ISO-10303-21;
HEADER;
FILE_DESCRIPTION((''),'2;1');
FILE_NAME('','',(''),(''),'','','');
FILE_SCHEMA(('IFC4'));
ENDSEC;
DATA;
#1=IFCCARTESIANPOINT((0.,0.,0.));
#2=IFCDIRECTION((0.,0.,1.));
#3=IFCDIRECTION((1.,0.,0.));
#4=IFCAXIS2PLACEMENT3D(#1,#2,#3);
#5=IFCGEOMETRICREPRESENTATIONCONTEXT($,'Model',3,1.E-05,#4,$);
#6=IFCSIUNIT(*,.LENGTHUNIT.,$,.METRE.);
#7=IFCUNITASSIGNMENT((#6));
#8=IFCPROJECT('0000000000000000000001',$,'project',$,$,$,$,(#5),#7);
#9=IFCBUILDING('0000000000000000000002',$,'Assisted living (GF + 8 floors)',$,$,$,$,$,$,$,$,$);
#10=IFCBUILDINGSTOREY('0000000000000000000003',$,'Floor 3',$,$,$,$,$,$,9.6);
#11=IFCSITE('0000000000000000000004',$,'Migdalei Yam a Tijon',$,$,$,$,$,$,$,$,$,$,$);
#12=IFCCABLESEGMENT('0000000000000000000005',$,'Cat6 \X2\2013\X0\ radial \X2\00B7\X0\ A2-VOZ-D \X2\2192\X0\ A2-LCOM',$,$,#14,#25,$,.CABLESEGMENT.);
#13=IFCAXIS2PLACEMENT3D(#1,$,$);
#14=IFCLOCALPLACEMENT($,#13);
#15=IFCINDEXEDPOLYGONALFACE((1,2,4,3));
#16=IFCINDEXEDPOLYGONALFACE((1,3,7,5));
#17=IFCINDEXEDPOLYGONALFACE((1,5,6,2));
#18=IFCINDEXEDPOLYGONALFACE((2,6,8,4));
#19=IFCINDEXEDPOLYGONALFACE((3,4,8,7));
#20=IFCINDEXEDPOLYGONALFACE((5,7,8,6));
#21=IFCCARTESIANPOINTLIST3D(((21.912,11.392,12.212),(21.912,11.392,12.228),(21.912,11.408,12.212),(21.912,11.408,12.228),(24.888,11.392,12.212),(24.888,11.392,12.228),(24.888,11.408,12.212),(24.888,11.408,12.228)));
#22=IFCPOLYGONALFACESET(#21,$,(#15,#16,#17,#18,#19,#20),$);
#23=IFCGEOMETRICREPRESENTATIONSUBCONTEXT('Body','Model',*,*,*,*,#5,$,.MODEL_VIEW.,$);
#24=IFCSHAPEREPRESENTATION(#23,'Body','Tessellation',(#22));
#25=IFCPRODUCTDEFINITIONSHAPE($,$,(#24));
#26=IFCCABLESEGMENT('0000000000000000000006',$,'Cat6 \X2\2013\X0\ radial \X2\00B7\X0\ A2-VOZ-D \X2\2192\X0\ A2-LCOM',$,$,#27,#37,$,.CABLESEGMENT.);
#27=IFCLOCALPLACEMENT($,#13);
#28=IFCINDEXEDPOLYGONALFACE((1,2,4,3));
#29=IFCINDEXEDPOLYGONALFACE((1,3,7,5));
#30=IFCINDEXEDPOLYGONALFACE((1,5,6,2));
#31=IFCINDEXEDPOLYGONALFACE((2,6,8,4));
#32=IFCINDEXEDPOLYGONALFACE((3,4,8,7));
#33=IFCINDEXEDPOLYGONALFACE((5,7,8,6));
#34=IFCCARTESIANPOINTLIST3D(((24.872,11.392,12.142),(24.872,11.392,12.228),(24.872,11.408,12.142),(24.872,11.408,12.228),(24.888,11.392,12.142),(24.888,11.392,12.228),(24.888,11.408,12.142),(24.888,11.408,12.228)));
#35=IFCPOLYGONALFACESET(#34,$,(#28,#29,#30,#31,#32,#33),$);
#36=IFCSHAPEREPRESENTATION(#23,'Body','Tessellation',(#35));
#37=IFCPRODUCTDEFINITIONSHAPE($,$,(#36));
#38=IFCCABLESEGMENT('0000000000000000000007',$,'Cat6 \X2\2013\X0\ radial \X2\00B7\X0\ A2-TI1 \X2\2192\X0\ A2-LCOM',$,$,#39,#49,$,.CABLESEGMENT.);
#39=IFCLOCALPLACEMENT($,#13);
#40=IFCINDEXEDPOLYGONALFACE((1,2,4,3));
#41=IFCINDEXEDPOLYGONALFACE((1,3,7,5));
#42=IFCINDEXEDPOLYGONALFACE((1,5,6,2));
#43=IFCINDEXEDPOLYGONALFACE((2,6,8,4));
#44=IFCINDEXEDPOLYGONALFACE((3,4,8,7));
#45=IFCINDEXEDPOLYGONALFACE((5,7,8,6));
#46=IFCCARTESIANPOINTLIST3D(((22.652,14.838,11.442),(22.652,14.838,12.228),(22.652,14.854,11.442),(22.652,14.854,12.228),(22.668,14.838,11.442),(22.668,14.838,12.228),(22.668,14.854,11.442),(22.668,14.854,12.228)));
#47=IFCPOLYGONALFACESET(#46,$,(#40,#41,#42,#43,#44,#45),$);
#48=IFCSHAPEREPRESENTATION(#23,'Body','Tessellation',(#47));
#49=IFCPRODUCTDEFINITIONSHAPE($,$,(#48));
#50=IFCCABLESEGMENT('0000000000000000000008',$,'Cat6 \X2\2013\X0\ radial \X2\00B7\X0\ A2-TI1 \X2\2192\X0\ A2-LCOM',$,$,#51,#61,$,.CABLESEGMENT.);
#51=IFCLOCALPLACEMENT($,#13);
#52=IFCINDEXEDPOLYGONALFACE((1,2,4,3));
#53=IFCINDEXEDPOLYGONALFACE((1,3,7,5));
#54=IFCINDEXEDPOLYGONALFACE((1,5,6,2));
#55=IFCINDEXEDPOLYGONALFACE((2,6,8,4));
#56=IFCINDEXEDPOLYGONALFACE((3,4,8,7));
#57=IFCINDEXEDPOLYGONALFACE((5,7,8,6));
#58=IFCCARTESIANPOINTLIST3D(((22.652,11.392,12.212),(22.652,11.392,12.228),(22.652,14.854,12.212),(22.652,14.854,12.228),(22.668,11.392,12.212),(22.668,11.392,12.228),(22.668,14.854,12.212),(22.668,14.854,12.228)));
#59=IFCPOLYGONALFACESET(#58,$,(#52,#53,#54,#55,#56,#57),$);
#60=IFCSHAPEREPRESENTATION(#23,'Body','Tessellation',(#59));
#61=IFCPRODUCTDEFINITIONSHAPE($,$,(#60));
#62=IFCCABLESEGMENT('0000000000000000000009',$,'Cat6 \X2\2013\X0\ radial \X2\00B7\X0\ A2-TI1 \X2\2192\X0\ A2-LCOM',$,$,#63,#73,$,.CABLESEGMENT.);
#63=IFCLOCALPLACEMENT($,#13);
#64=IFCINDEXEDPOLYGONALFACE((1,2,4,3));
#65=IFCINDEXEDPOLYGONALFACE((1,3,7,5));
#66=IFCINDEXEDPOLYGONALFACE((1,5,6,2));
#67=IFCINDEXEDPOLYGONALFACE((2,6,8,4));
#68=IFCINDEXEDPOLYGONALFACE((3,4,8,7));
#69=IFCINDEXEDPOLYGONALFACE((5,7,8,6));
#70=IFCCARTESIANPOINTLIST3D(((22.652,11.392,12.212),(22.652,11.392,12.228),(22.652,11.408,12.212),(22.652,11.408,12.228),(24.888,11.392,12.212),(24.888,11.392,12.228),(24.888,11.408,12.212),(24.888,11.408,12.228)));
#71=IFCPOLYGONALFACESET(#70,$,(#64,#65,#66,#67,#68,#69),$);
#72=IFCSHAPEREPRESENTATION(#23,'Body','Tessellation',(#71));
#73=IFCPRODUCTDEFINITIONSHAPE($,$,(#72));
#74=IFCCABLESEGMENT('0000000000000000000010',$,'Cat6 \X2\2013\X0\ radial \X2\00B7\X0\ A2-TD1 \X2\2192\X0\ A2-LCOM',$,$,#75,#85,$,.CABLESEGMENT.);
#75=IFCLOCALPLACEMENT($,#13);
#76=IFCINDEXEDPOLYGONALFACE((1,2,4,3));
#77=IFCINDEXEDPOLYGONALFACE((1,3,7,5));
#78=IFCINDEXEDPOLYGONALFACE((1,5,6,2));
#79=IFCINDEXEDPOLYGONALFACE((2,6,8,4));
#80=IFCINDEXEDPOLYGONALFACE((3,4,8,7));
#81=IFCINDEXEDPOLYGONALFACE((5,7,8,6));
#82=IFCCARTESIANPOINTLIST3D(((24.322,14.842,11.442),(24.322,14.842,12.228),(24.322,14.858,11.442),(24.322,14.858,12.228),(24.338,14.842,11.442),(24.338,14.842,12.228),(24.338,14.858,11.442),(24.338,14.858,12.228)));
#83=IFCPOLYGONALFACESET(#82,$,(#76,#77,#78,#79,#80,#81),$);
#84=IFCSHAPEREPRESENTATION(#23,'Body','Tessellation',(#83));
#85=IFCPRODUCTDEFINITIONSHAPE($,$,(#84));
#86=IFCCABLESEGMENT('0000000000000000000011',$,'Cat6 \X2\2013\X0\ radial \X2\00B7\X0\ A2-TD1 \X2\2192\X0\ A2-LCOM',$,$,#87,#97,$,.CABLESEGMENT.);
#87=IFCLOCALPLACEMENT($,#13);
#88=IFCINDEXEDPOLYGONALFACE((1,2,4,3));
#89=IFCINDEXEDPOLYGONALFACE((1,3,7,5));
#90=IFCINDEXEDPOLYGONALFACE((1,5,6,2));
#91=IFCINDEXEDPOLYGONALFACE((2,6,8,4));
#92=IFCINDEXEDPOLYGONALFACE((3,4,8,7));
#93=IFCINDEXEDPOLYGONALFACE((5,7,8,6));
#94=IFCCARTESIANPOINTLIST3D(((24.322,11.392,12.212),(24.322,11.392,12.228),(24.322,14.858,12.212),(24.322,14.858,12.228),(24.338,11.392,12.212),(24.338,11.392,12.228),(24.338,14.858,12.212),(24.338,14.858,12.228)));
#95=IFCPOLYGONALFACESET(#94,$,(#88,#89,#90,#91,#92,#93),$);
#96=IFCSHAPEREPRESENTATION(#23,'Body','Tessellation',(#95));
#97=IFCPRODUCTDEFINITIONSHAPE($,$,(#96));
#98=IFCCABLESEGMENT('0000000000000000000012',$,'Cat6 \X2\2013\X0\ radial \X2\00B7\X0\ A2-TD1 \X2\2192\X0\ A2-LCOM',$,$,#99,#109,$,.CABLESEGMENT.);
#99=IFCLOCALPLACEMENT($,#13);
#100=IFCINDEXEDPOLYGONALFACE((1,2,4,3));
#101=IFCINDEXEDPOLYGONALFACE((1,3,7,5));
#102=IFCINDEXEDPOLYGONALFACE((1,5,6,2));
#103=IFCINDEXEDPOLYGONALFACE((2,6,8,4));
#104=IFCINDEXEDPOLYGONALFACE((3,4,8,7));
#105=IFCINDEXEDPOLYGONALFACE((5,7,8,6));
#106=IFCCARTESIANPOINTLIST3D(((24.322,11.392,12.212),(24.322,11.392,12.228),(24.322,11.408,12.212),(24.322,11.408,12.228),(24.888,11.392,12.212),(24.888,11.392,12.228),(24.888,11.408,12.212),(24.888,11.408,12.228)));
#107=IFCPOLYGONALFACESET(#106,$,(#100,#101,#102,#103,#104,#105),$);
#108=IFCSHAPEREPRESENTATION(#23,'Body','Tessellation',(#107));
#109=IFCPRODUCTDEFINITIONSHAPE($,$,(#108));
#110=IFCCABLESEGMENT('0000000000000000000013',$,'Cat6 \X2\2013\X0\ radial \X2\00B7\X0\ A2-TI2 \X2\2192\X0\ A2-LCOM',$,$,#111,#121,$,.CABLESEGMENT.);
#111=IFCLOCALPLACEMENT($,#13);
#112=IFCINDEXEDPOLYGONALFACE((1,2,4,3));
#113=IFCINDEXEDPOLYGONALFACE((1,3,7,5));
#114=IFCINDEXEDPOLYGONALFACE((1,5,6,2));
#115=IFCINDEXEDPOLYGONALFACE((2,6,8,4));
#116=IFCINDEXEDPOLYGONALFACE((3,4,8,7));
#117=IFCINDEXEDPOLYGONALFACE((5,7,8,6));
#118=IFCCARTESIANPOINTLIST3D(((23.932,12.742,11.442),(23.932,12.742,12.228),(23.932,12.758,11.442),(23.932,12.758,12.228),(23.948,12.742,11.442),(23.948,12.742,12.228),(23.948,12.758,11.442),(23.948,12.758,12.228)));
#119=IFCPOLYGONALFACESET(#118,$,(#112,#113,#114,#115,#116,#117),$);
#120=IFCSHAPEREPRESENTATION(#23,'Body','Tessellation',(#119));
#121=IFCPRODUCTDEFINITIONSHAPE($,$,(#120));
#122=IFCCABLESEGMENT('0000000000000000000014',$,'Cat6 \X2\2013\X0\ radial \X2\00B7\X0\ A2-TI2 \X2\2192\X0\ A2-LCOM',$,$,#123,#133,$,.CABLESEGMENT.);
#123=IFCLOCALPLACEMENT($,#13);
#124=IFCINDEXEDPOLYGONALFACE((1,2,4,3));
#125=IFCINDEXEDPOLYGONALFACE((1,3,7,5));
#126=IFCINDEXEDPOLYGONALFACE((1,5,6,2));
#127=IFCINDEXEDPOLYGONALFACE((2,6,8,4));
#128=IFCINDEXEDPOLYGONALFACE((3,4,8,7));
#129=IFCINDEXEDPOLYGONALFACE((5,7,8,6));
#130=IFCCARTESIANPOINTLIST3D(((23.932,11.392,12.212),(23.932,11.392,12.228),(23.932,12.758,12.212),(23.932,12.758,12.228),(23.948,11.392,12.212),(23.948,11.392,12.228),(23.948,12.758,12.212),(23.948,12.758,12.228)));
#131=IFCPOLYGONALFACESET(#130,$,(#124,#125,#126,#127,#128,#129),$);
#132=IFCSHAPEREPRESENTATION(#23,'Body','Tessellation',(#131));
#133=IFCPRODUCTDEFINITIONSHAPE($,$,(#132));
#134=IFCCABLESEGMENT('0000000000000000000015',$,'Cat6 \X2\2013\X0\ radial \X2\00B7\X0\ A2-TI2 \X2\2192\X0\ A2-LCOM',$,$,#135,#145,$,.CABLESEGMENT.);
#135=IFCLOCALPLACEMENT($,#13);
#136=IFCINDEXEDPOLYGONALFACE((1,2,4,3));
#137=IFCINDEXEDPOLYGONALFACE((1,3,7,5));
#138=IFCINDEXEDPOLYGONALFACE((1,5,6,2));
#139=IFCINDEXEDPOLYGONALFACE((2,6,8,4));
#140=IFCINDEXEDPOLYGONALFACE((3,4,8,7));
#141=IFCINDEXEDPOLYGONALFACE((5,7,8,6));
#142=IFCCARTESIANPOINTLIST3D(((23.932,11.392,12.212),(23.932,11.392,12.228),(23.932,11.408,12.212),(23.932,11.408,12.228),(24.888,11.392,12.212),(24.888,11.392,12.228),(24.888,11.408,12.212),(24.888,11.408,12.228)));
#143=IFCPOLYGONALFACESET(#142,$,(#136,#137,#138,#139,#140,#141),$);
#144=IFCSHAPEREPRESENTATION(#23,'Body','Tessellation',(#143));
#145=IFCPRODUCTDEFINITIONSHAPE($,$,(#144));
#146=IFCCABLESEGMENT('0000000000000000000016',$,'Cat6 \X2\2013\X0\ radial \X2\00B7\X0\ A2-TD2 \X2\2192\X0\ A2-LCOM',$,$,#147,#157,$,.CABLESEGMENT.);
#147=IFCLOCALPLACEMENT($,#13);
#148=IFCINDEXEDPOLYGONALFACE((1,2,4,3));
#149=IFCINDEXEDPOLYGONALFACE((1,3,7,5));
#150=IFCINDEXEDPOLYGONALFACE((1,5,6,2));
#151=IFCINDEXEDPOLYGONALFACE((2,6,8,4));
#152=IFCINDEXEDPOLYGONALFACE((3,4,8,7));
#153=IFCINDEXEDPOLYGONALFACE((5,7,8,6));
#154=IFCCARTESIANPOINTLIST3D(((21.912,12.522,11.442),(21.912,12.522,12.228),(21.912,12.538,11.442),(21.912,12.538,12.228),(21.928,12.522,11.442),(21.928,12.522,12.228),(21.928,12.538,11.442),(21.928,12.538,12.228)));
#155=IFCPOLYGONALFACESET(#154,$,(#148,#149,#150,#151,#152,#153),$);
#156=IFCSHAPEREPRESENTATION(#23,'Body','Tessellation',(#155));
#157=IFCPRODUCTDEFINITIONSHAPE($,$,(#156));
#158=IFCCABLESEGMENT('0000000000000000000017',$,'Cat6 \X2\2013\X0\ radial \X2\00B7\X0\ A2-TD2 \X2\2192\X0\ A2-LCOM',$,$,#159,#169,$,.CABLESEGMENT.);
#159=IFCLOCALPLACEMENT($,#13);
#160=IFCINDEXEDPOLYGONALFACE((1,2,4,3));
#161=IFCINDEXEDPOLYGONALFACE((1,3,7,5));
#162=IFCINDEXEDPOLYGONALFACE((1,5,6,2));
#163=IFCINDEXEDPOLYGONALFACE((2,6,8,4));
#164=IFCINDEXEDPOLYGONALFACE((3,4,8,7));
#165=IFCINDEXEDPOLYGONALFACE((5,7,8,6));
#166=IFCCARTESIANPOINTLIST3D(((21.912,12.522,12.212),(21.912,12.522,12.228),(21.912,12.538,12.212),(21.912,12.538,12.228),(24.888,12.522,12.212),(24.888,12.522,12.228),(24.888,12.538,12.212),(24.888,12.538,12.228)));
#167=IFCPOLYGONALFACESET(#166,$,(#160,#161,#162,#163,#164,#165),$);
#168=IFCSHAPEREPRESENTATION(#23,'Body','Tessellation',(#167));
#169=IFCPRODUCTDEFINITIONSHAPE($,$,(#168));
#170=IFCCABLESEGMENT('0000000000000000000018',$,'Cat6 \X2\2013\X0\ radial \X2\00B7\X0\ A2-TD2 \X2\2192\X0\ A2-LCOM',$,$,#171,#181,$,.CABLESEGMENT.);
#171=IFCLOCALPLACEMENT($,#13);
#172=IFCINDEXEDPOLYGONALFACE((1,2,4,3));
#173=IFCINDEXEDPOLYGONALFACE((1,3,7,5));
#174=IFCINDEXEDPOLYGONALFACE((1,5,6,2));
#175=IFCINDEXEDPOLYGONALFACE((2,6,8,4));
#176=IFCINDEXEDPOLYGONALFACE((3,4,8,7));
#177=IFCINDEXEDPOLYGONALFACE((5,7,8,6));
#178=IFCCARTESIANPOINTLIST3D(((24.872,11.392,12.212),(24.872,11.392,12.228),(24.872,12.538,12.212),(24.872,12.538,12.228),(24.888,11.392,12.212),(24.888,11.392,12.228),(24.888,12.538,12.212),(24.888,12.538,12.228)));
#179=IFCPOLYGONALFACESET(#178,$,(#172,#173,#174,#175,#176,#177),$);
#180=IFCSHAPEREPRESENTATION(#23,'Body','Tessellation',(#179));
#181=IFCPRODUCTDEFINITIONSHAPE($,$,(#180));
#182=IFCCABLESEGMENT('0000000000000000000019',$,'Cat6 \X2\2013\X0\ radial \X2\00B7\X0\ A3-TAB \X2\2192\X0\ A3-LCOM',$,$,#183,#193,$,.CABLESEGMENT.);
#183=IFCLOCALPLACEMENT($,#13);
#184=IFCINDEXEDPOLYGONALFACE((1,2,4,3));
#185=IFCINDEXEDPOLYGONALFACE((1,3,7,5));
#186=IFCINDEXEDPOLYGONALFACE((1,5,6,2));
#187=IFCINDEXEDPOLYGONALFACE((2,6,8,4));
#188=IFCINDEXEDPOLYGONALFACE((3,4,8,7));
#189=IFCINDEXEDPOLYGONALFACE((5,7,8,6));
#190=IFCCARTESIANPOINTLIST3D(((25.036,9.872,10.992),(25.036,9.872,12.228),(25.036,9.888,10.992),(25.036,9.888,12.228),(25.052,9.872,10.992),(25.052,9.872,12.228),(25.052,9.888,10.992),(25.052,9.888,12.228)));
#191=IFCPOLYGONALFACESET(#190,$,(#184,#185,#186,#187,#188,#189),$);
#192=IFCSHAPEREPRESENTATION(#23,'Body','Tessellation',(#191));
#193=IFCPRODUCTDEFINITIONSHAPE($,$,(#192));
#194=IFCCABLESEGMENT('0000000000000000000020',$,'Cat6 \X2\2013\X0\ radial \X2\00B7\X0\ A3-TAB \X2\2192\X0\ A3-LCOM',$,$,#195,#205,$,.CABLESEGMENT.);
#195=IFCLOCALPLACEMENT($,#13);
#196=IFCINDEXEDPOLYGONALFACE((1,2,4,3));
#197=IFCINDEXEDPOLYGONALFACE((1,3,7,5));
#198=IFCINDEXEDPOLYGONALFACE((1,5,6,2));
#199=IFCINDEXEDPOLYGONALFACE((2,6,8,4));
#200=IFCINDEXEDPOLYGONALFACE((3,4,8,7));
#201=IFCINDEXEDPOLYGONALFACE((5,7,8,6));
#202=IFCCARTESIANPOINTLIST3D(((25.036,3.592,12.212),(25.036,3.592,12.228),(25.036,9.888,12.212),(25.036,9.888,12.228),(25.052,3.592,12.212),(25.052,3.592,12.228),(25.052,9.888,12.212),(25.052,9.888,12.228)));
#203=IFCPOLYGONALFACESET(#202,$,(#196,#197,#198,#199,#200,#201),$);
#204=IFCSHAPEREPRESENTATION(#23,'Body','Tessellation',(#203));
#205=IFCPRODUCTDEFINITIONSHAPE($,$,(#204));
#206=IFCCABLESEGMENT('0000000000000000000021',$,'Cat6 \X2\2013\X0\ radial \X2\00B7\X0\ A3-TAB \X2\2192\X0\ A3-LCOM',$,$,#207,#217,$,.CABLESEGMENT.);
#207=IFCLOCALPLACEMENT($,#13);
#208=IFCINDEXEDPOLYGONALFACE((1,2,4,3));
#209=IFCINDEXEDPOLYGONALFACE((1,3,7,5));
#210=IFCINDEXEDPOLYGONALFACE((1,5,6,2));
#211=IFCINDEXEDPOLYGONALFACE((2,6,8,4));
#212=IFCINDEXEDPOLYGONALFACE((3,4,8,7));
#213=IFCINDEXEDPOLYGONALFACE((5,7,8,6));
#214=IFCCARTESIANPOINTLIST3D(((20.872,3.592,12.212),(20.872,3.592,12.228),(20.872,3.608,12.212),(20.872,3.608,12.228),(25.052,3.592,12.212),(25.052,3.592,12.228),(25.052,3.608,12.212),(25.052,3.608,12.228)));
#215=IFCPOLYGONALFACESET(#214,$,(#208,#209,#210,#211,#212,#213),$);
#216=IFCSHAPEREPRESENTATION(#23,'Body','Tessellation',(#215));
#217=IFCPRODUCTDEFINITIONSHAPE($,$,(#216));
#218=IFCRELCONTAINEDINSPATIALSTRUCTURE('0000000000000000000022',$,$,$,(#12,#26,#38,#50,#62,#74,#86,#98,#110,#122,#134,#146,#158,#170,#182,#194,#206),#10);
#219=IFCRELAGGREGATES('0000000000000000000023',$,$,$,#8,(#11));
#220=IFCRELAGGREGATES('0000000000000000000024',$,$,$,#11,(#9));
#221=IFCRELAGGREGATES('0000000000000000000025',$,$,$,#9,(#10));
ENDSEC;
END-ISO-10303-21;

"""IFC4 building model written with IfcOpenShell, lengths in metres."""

from ifc_helpers import new_model, si_unit, frame, origin_with_axes, context, subcontext, project, spatial, line, indexed_curve, outline, extrude, element, save


model = new_model("IFC4")

# Units and contexts
model_context = context("Model", 3, precision=1e-05, world=origin_with_axes())
body_context = subcontext(model_context, "Body", "Model", "MODEL_VIEW")
ifc_project = project(units=[si_unit("LENGTHUNIT", "METRE")], contexts=[model_context])

# Site, building, storey
site = spatial("IfcSite", under=ifc_project, Name="Migdalei Yam a Tijon")
building = spatial("IfcBuilding", under=site, Name="Assisted living (GF + 8 floors)")
storey = spatial("IfcBuildingStorey", under=building, Name="Floor 3", Elevation=9.6)

# Cable segments
element("IfcCableSegment", 1, inside=storey, Name="Cat6 – radial · A2-VOZ-D → A2-LCOM", PredefinedType="CABLESEGMENT", context=body_context, shape_type="SweptSolid", body=[
    extrude(outline(indexed_curve([(0.0, 0.0), (2.976, 0.0), (2.976, 0.016), (0.0, 0.016)], segments=[line(1, 2, 3, 4, 1)])), frame((21.912, 11.392, 12.212), z_axis=(0.0, 0.0, 1.0), x_axis=(1.0, 0.0, 0.0)), (0.0, 0.0, 1.0), 0.016),
])
element("IfcCableSegment", 2, inside=storey, Name="Cat6 – radial · A2-VOZ-D → A2-LCOM", PredefinedType="CABLESEGMENT", context=body_context, shape_type="SweptSolid", body=[
    extrude(outline(indexed_curve([(0.0, 0.0), (0.016, 0.0), (0.016, 0.016), (0.0, 0.016)], segments=[line(1, 2, 3, 4, 1)])), frame((24.872, 11.392, 12.142), z_axis=(0.0, 0.0, 1.0), x_axis=(1.0, 0.0, 0.0)), (0.0, 0.0, 1.0), 0.086),
])
element("IfcCableSegment", 3, inside=storey, Name="Cat6 – radial · A2-TI1 → A2-LCOM", PredefinedType="CABLESEGMENT", context=body_context, shape_type="SweptSolid", body=[
    extrude(outline(indexed_curve([(0.0, 0.0), (0.016, 0.0), (0.016, 0.016), (0.0, 0.016)], segments=[line(1, 2, 3, 4, 1)])), frame((22.652, 14.838, 11.442), z_axis=(0.0, 0.0, 1.0), x_axis=(1.0, 0.0, 0.0)), (0.0, 0.0, 1.0), 0.786),
])
element("IfcCableSegment", 4, inside=storey, Name="Cat6 – radial · A2-TI1 → A2-LCOM", PredefinedType="CABLESEGMENT", context=body_context, shape_type="SweptSolid", body=[
    extrude(outline(indexed_curve([(0.0, 0.0), (0.016, 0.0), (0.016, 3.462), (0.0, 3.462)], segments=[line(1, 2, 3, 4, 1)])), frame((22.652, 11.392, 12.212), z_axis=(0.0, 0.0, 1.0), x_axis=(1.0, 0.0, 0.0)), (0.0, 0.0, 1.0), 0.016),
])
element("IfcCableSegment", 5, inside=storey, Name="Cat6 – radial · A2-TI1 → A2-LCOM", PredefinedType="CABLESEGMENT", context=body_context, shape_type="SweptSolid", body=[
    extrude(outline(indexed_curve([(0.0, 0.0), (2.236, 0.0), (2.236, 0.016), (0.0, 0.016)], segments=[line(1, 2, 3, 4, 1)])), frame((22.652, 11.392, 12.212), z_axis=(0.0, 0.0, 1.0), x_axis=(1.0, 0.0, 0.0)), (0.0, 0.0, 1.0), 0.016),
])
element("IfcCableSegment", 6, inside=storey, Name="Cat6 – radial · A2-TD1 → A2-LCOM", PredefinedType="CABLESEGMENT", context=body_context, shape_type="SweptSolid", body=[
    extrude(outline(indexed_curve([(0.0, 0.0), (0.016, 0.0), (0.016, 0.016), (0.0, 0.016)], segments=[line(1, 2, 3, 4, 1)])), frame((24.322, 14.842, 11.442), z_axis=(0.0, 0.0, 1.0), x_axis=(1.0, 0.0, 0.0)), (0.0, 0.0, 1.0), 0.786),
])
element("IfcCableSegment", 7, inside=storey, Name="Cat6 – radial · A2-TD1 → A2-LCOM", PredefinedType="CABLESEGMENT", context=body_context, shape_type="SweptSolid", body=[
    extrude(outline(indexed_curve([(0.0, 0.0), (0.016, 0.0), (0.016, 3.466), (0.0, 3.466)], segments=[line(1, 2, 3, 4, 1)])), frame((24.322, 11.392, 12.212), z_axis=(0.0, 0.0, 1.0), x_axis=(1.0, 0.0, 0.0)), (0.0, 0.0, 1.0), 0.016),
])
element("IfcCableSegment", 8, inside=storey, Name="Cat6 – radial · A2-TD1 → A2-LCOM", PredefinedType="CABLESEGMENT", context=body_context, shape_type="SweptSolid", body=[
    extrude(outline(indexed_curve([(0.0, 0.0), (0.566, 0.0), (0.566, 0.016), (0.0, 0.016)], segments=[line(1, 2, 3, 4, 1)])), frame((24.322, 11.392, 12.212), z_axis=(0.0, 0.0, 1.0), x_axis=(1.0, 0.0, 0.0)), (0.0, 0.0, 1.0), 0.016),
])
element("IfcCableSegment", 9, inside=storey, Name="Cat6 – radial · A2-TI2 → A2-LCOM", PredefinedType="CABLESEGMENT", context=body_context, shape_type="SweptSolid", body=[
    extrude(outline(indexed_curve([(0.0, 0.0), (0.016, 0.0), (0.016, 0.016), (0.0, 0.016)], segments=[line(1, 2, 3, 4, 1)])), frame((23.932, 12.742, 11.442), z_axis=(0.0, 0.0, 1.0), x_axis=(1.0, 0.0, 0.0)), (0.0, 0.0, 1.0), 0.786),
])
element("IfcCableSegment", 10, inside=storey, Name="Cat6 – radial · A2-TI2 → A2-LCOM", PredefinedType="CABLESEGMENT", context=body_context, shape_type="SweptSolid", body=[
    extrude(outline(indexed_curve([(0.0, 0.0), (0.016, 0.0), (0.016, 1.366), (0.0, 1.366)], segments=[line(1, 2, 3, 4, 1)])), frame((23.932, 11.392, 12.212), z_axis=(0.0, 0.0, 1.0), x_axis=(1.0, 0.0, 0.0)), (0.0, 0.0, 1.0), 0.016),
])
element("IfcCableSegment", 11, inside=storey, Name="Cat6 – radial · A2-TI2 → A2-LCOM", PredefinedType="CABLESEGMENT", context=body_context, shape_type="SweptSolid", body=[
    extrude(outline(indexed_curve([(0.0, 0.0), (0.956, 0.0), (0.956, 0.016), (0.0, 0.016)], segments=[line(1, 2, 3, 4, 1)])), frame((23.932, 11.392, 12.212), z_axis=(0.0, 0.0, 1.0), x_axis=(1.0, 0.0, 0.0)), (0.0, 0.0, 1.0), 0.016),
])
element("IfcCableSegment", 12, inside=storey, Name="Cat6 – radial · A2-TD2 → A2-LCOM", PredefinedType="CABLESEGMENT", context=body_context, shape_type="SweptSolid", body=[
    extrude(outline(indexed_curve([(0.0, 0.0), (0.016, 0.0), (0.016, 0.016), (0.0, 0.016)], segments=[line(1, 2, 3, 4, 1)])), frame((21.912, 12.522, 11.442), z_axis=(0.0, 0.0, 1.0), x_axis=(1.0, 0.0, 0.0)), (0.0, 0.0, 1.0), 0.786),
])
element("IfcCableSegment", 13, inside=storey, Name="Cat6 – radial · A2-TD2 → A2-LCOM", PredefinedType="CABLESEGMENT", context=body_context, shape_type="SweptSolid", body=[
    extrude(outline(indexed_curve([(0.0, 0.0), (2.976, 0.0), (2.976, 0.016), (0.0, 0.016)], segments=[line(1, 2, 3, 4, 1)])), frame((21.912, 12.522, 12.212), z_axis=(0.0, 0.0, 1.0), x_axis=(1.0, 0.0, 0.0)), (0.0, 0.0, 1.0), 0.016),
])
element("IfcCableSegment", 14, inside=storey, Name="Cat6 – radial · A2-TD2 → A2-LCOM", PredefinedType="CABLESEGMENT", context=body_context, shape_type="SweptSolid", body=[
    extrude(outline(indexed_curve([(0.0, 0.0), (0.016, 0.0), (0.016, 1.146), (0.0, 1.146)], segments=[line(1, 2, 3, 4, 1)])), frame((24.872, 11.392, 12.212), z_axis=(0.0, 0.0, 1.0), x_axis=(1.0, 0.0, 0.0)), (0.0, 0.0, 1.0), 0.016),
])
element("IfcCableSegment", 15, inside=storey, Name="Cat6 – radial · A3-TAB → A3-LCOM", PredefinedType="CABLESEGMENT", context=body_context, shape_type="SweptSolid", body=[
    extrude(outline(indexed_curve([(0.0, 0.0), (0.016, 0.0), (0.016, 0.016), (0.0, 0.016)], segments=[line(1, 2, 3, 4, 1)])), frame((25.036, 9.872, 10.992), z_axis=(0.0, 0.0, 1.0), x_axis=(1.0, 0.0, 0.0)), (0.0, 0.0, 1.0), 1.236),
])
element("IfcCableSegment", 16, inside=storey, Name="Cat6 – radial · A3-TAB → A3-LCOM", PredefinedType="CABLESEGMENT", context=body_context, shape_type="SweptSolid", body=[
    extrude(outline(indexed_curve([(0.0, 0.0), (0.016, 0.0), (0.016, 6.296), (0.0, 6.296)], segments=[line(1, 2, 3, 4, 1)])), frame((25.036, 3.592, 12.212), z_axis=(0.0, 0.0, 1.0), x_axis=(1.0, 0.0, 0.0)), (0.0, 0.0, 1.0), 0.016),
])
element("IfcCableSegment", 17, inside=storey, Name="Cat6 – radial · A3-TAB → A3-LCOM", PredefinedType="CABLESEGMENT", context=body_context, shape_type="SweptSolid", body=[
    extrude(outline(indexed_curve([(0.0, 0.0), (4.18, 0.0), (4.18, 0.016), (0.0, 0.016)], segments=[line(1, 2, 3, 4, 1)])), frame((20.872, 3.592, 12.212), z_axis=(0.0, 0.0, 1.0), x_axis=(1.0, 0.0, 0.0)), (0.0, 0.0, 1.0), 0.016),
])

save(model, "model.ifc")
